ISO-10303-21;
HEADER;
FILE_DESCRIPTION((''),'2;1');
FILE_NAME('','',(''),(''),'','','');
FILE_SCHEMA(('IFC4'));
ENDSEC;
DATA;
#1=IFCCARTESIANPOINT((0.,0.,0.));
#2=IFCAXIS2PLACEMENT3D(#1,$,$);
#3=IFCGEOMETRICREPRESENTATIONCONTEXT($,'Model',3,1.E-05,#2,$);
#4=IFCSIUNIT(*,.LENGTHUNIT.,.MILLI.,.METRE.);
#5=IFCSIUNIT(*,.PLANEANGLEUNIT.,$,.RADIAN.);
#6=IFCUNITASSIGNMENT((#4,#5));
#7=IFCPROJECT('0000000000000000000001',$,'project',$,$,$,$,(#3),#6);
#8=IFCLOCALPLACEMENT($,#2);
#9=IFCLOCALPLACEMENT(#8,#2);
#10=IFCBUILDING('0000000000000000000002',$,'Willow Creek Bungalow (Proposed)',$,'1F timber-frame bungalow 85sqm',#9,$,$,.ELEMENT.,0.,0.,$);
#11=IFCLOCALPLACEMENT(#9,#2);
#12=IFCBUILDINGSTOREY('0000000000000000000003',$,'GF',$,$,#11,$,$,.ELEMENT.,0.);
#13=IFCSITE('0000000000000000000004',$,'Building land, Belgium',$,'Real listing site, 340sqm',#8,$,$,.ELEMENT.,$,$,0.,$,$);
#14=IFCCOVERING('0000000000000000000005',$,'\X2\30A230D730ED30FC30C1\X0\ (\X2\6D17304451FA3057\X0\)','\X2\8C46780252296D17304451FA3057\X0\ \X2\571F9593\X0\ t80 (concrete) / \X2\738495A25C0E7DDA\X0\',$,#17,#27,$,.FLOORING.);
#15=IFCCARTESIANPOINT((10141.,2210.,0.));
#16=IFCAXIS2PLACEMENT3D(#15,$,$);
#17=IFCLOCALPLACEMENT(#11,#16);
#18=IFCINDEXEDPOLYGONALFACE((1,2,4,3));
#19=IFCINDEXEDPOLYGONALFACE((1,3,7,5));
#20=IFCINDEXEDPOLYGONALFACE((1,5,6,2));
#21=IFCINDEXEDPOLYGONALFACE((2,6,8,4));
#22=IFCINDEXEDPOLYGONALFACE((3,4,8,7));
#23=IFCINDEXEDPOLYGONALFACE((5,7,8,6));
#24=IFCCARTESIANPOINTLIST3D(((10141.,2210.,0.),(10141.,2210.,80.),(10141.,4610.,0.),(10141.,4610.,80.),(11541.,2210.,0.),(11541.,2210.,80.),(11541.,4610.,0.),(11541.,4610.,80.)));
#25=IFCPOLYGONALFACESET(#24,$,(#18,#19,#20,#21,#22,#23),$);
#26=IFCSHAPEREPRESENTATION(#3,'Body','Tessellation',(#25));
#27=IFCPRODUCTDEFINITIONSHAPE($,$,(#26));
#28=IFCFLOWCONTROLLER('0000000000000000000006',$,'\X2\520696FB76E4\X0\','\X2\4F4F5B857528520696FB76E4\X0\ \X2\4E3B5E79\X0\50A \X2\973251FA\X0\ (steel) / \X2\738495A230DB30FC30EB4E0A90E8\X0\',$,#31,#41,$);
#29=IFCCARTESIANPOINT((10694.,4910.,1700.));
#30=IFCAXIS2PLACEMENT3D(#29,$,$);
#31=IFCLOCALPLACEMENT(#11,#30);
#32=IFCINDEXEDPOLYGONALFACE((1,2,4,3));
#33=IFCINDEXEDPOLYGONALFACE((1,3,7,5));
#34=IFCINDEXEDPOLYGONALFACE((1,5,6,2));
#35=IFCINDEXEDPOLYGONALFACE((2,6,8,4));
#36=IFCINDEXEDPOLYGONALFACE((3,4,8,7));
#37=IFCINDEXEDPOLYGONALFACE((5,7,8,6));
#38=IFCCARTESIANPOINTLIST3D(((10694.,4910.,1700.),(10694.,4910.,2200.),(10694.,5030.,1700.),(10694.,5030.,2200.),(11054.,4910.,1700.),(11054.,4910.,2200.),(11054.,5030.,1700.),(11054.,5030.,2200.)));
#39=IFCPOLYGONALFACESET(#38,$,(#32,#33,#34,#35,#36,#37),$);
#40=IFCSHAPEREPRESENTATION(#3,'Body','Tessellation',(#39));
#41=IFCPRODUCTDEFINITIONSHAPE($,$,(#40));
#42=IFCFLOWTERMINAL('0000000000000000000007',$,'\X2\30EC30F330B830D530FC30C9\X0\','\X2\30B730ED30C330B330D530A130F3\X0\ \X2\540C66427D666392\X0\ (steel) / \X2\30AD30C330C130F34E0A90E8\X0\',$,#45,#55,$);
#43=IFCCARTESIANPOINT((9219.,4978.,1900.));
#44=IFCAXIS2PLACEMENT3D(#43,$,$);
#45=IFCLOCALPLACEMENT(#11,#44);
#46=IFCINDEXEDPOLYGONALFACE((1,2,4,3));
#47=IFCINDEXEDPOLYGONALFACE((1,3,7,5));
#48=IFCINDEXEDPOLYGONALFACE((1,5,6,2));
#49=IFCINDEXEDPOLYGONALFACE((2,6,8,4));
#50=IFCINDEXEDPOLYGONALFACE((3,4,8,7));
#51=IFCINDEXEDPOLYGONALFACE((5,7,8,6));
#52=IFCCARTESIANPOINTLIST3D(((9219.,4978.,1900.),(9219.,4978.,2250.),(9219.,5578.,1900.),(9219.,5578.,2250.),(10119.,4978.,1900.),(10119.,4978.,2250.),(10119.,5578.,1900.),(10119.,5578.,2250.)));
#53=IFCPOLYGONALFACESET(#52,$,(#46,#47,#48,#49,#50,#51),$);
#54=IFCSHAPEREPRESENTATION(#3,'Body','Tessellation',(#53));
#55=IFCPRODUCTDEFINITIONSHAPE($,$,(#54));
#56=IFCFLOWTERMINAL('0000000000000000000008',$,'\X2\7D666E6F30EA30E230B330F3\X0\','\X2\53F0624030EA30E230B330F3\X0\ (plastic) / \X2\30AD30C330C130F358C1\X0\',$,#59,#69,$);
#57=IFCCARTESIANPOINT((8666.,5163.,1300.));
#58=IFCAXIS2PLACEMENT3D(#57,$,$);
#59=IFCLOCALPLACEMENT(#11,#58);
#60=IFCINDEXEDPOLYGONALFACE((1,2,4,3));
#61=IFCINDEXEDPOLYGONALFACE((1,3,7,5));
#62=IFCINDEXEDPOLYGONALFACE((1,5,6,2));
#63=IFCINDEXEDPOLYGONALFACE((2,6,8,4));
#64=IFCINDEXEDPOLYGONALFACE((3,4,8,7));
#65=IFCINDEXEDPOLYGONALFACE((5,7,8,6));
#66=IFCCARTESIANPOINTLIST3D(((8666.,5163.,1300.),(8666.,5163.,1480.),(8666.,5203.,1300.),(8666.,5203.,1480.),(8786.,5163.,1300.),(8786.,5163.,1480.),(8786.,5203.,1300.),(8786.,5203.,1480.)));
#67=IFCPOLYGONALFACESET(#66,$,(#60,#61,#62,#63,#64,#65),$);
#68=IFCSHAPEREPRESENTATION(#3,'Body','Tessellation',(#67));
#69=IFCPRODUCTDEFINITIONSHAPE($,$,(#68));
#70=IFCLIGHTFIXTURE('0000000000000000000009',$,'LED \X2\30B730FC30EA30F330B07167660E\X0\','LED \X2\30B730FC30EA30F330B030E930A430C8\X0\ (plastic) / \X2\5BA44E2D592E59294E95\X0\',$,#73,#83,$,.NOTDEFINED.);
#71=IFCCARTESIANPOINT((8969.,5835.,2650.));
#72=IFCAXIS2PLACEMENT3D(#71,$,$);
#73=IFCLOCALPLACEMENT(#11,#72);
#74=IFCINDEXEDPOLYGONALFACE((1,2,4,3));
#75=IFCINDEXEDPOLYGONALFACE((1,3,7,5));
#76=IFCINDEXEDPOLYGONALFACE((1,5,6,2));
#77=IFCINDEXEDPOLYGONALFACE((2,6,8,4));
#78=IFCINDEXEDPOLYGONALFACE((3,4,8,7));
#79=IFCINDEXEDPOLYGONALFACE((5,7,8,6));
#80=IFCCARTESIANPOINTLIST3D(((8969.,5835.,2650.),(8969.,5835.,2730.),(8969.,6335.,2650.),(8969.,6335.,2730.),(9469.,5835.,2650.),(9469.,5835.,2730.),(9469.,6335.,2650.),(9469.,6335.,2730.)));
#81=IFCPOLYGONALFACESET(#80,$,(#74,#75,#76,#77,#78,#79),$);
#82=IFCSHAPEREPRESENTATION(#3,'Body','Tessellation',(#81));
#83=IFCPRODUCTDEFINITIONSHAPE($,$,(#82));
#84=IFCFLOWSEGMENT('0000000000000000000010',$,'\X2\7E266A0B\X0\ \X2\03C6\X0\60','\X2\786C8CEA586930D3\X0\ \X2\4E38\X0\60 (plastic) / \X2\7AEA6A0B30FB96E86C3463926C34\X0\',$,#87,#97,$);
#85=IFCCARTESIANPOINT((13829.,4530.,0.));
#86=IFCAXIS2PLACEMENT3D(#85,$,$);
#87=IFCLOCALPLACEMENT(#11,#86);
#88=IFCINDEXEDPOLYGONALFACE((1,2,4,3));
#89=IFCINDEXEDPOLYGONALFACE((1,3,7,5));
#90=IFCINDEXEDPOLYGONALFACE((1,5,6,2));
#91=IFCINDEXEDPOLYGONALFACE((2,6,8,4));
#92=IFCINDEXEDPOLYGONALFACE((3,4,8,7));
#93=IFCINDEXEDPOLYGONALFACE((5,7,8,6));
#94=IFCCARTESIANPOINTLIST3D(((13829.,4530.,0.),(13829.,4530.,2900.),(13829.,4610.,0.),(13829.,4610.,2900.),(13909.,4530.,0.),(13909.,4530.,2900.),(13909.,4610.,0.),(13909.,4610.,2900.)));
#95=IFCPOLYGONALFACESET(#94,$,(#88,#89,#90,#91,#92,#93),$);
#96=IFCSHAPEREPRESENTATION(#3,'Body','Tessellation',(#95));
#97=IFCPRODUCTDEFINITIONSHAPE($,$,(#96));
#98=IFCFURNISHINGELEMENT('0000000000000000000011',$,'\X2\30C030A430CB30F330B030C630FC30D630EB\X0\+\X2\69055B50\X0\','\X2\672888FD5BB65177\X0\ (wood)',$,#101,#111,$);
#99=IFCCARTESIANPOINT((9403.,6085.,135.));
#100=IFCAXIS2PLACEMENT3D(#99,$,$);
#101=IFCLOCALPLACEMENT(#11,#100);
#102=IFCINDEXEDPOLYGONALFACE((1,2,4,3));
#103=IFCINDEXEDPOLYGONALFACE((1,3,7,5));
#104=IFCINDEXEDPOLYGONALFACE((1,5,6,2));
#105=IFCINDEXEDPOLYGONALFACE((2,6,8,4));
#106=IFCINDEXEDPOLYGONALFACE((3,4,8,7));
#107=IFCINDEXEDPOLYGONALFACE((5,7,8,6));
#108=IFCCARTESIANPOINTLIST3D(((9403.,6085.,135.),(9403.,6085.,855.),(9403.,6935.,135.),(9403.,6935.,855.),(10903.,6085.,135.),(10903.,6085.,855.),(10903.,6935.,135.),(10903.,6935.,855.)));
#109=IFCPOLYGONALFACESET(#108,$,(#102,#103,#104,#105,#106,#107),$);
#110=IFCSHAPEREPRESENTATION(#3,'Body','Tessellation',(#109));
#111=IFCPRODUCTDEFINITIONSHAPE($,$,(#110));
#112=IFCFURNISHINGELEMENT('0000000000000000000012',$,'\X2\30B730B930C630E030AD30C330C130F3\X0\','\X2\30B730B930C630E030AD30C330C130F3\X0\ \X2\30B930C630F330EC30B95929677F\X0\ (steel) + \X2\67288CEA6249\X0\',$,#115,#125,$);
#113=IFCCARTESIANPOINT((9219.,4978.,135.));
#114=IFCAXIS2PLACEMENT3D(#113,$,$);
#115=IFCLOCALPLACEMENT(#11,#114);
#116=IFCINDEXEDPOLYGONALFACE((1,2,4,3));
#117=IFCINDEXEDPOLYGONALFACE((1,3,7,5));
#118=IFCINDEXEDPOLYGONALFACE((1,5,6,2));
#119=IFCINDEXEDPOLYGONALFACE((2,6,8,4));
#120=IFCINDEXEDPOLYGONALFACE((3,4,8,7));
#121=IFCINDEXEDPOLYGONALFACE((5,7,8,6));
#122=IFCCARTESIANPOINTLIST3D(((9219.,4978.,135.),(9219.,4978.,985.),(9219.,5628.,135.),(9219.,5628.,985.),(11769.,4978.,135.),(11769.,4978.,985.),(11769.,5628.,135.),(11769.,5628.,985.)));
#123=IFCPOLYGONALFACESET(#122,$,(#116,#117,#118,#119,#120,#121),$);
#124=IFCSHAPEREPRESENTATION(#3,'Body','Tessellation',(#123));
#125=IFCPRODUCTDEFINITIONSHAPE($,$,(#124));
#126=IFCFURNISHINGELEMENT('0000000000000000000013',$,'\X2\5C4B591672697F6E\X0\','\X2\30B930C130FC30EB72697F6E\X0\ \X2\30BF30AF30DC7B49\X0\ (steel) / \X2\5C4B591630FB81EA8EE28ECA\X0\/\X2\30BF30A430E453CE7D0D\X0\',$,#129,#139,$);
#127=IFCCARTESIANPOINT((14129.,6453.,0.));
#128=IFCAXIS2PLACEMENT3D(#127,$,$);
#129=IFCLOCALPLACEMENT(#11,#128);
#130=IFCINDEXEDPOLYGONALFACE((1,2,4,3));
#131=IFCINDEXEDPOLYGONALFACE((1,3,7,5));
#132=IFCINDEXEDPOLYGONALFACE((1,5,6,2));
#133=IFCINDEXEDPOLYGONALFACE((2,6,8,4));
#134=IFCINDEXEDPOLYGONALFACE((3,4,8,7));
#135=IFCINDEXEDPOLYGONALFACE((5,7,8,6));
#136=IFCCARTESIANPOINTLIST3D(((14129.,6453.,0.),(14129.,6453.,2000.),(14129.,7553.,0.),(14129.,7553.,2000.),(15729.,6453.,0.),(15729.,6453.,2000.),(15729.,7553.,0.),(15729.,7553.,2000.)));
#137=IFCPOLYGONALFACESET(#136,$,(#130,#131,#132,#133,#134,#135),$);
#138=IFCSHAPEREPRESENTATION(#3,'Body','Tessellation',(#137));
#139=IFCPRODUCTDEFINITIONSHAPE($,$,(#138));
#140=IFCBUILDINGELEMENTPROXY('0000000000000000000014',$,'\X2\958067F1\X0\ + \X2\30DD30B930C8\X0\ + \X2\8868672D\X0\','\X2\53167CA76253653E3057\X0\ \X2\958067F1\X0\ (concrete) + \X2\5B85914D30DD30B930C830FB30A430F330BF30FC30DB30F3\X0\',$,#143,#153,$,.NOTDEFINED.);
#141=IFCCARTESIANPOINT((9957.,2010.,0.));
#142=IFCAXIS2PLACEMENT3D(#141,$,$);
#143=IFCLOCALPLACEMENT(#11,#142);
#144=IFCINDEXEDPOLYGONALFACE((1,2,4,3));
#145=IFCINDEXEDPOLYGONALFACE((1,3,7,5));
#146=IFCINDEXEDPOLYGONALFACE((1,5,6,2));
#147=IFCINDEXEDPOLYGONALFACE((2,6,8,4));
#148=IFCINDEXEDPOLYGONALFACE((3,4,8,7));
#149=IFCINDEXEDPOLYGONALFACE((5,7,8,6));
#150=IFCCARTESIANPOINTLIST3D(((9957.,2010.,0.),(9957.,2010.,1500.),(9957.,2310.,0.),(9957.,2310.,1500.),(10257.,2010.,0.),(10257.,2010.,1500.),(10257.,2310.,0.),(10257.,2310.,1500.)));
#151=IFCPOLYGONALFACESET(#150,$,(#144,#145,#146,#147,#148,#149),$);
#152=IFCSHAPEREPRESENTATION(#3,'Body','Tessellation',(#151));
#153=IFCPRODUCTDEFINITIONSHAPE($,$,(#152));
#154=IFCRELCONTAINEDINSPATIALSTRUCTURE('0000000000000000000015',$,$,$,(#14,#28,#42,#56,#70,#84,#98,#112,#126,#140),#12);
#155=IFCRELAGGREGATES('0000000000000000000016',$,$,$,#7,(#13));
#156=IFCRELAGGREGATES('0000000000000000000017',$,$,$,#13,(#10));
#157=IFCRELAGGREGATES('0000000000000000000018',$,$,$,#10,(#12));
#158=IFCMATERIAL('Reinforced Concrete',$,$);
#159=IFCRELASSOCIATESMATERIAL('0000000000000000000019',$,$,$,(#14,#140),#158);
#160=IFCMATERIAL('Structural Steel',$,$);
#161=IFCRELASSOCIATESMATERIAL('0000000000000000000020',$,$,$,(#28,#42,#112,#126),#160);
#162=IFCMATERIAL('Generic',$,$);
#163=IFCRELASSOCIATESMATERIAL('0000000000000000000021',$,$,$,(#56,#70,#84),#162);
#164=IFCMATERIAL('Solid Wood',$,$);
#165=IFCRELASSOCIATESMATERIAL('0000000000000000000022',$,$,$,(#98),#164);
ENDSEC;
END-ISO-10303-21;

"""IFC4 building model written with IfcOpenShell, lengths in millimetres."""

from ifc_helpers import new_model, si_unit, frame, frame_2d, origin, place, context, project, spatial, rectangle, extrude, material, element, save


model = new_model("IFC4")

# Units and contexts
model_context = context("Model", 3, precision=1e-05, world=origin())
ifc_project = project(units=[si_unit("LENGTHUNIT", "METRE", prefix="MILLI"), si_unit("PLANEANGLEUNIT", "RADIAN")], contexts=[model_context])

# Site, building, storey
site_placement = place(None, origin())
site = spatial("IfcSite", under=ifc_project, at=site_placement, Name="Building land, Belgium", ObjectType="Real listing site, 340sqm", CompositionType="ELEMENT", RefElevation=0.0)
building_placement = place(site_placement, origin())
building = spatial("IfcBuilding", under=site, at=building_placement, Name="Willow Creek Bungalow (Proposed)", ObjectType="1F timber-frame bungalow 85sqm", CompositionType="ELEMENT", ElevationOfRefHeight=0.0, ElevationOfTerrain=0.0)
storey_placement = place(building_placement, origin())
storey = spatial("IfcBuildingStorey", under=building, at=storey_placement, Name="GF", CompositionType="ELEMENT", Elevation=0.0)

# Shared definitions
ifc_material_1 = material(Name="Solid Wood")

# Shared definitions
ifc_material_2 = material(Name="Structural Steel")

# Covering
ifc_material_3 = material(Name="Reinforced Concrete")
covering_placement = place(storey_placement, frame((10141.0, 2210.0, 0.0)))
element("IfcCovering", 1, at=covering_placement, inside=storey, material=ifc_material_3, Name="アプローチ (洗い出し)", Description="豆砂利洗い出し 土間 t80 (concrete) / 玄関導線", PredefinedType="FLOORING", context=model_context, shape_type="SweptSolid", body=[
    extrude(rectangle(XDim=1400.0, YDim=2400.0, at=frame_2d((700.0, 1200.0))), frame((10141.0, 2210.0, 0.0)), (0.0, 0.0, 1.0), 80.0),
])

# Flow controller
flow_controller_placement = place(storey_placement, frame((10694.0, 4910.0, 1700.0)))
element("IfcFlowController", 2, at=flow_controller_placement, inside=storey, material=ifc_material_2, Name="分電盤", Description="住宅用分電盤 主幹50A 露出 (steel) / 玄関ホール上部", context=model_context, shape_type="SweptSolid", body=[
    extrude(rectangle(XDim=360.0, YDim=120.0, at=frame_2d((180.0, 60.0))), frame((10694.0, 4910.0, 1700.0)), (0.0, 0.0, 1.0), 500.0),
])

# Flow terminals
flow_terminal_1_placement = place(storey_placement, frame((9219.0, 4978.0, 1900.0)))
element("IfcFlowTerminal", 3, at=flow_terminal_1_placement, inside=storey, material=ifc_material_2, Name="レンジフード", Description="シロッコファン 同時給排 (steel) / キッチン上部", context=model_context, shape_type="SweptSolid", body=[
    extrude(rectangle(XDim=900.0, YDim=600.0, at=frame_2d((450.0, 300.0))), frame((9219.0, 4978.0, 1900.0)), (0.0, 0.0, 1.0), 350.0),
])
ifc_material_4 = material(Name="Generic")
flow_terminal_2_placement = place(storey_placement, frame((8666.0, 5163.0, 1300.0)))
element("IfcFlowTerminal", 4, at=flow_terminal_2_placement, inside=storey, material=ifc_material_4, Name="給湯リモコン", Description="台所リモコン (plastic) / キッチン壁", context=model_context, shape_type="SweptSolid", body=[
    extrude(rectangle(XDim=120.0, YDim=40.0, at=frame_2d((60.0, 20.0))), frame((8666.0, 5163.0, 1300.0)), (0.0, 0.0, 1.0), 180.0),
])

# Light fixture
light_fixture_placement = place(storey_placement, frame((8969.0, 5835.0, 2650.0)))
element("IfcLightFixture", 5, at=light_fixture_placement, inside=storey, material=ifc_material_4, Name="LED シーリング照明", Description="LED シーリングライト (plastic) / 室中央天井", PredefinedType="NOTDEFINED", context=model_context, shape_type="SweptSolid", body=[
    extrude(rectangle(XDim=500.0, YDim=500.0, at=frame_2d((250.0, 250.0))), frame((8969.0, 5835.0, 2650.0)), (0.0, 0.0, 1.0), 80.0),
])

# Flow segment
flow_segment_placement = place(storey_placement, frame((13829.0, 4530.0, 0.0)))
element("IfcFlowSegment", 6, at=flow_segment_placement, inside=storey, material=ifc_material_4, Name="縦樋 φ60", Description="硬質塩ビ 丸60 (plastic) / 竪樋・雨水排水", context=model_context, shape_type="SweptSolid", body=[
    extrude(rectangle(XDim=80.0, YDim=80.0, at=frame_2d((40.0, 40.0))), frame((13829.0, 4530.0, 0.0)), (0.0, 0.0, 1.0), 2900.0),
])

# Furnishing elements
furnishing_1_placement = place(storey_placement, frame((9403.0, 6085.0, 135.0)))
element("IfcFurnishingElement", 7, at=furnishing_1_placement, inside=storey, material=ifc_material_1, Name="ダイニングテーブル+椅子", Description="木製家具 (wood)", context=model_context, shape_type="SweptSolid", body=[
    extrude(rectangle(XDim=1500.0, YDim=850.0, at=frame_2d((750.0, 425.0))), frame((9403.0, 6085.0, 135.0)), (0.0, 0.0, 1.0), 720.0),
])
furnishing_2_placement = place(storey_placement, frame((9219.0, 4978.0, 135.0)))
element("IfcFurnishingElement", 8, at=furnishing_2_placement, inside=storey, material=ifc_material_2, Name="システムキッチン", Description="システムキッチン ステンレス天板 (steel) + 木質扉", context=model_context, shape_type="SweptSolid", body=[
    extrude(rectangle(XDim=2550.0, YDim=650.0, at=frame_2d((1275.0, 325.0))), frame((9219.0, 4978.0, 135.0)), (0.0, 0.0, 1.0), 850.0),
])
furnishing_3_placement = place(storey_placement, frame((14129.0, 6453.0, 0.0)))
element("IfcFurnishingElement", 9, at=furnishing_3_placement, inside=storey, material=ifc_material_2, Name="屋外物置", Description="スチール物置 タクボ等 (steel) / 屋外・自転車/タイヤ収納", context=model_context, shape_type="SweptSolid", body=[
    extrude(rectangle(XDim=1600.0, YDim=1100.0, at=frame_2d((800.0, 550.0))), frame((14129.0, 6453.0, 0.0)), (0.0, 0.0, 1.0), 2000.0),
])

# Building element proxy
proxy_placement = place(storey_placement, frame((9957.0, 2010.0, 0.0)))
element("IfcBuildingElementProxy", 10, at=proxy_placement, inside=storey, material=ifc_material_3, Name="門柱 + ポスト + 表札", Description="化粧打放し 門柱 (concrete) + 宅配ポスト・インターホン", PredefinedType="NOTDEFINED", context=model_context, shape_type="SweptSolid", body=[
    extrude(rectangle(XDim=300.0, YDim=300.0, at=frame_2d((150.0, 150.0))), frame((9957.0, 2010.0, 0.0)), (0.0, 0.0, 1.0), 1500.0),
])

save(model, "model.ifc")
